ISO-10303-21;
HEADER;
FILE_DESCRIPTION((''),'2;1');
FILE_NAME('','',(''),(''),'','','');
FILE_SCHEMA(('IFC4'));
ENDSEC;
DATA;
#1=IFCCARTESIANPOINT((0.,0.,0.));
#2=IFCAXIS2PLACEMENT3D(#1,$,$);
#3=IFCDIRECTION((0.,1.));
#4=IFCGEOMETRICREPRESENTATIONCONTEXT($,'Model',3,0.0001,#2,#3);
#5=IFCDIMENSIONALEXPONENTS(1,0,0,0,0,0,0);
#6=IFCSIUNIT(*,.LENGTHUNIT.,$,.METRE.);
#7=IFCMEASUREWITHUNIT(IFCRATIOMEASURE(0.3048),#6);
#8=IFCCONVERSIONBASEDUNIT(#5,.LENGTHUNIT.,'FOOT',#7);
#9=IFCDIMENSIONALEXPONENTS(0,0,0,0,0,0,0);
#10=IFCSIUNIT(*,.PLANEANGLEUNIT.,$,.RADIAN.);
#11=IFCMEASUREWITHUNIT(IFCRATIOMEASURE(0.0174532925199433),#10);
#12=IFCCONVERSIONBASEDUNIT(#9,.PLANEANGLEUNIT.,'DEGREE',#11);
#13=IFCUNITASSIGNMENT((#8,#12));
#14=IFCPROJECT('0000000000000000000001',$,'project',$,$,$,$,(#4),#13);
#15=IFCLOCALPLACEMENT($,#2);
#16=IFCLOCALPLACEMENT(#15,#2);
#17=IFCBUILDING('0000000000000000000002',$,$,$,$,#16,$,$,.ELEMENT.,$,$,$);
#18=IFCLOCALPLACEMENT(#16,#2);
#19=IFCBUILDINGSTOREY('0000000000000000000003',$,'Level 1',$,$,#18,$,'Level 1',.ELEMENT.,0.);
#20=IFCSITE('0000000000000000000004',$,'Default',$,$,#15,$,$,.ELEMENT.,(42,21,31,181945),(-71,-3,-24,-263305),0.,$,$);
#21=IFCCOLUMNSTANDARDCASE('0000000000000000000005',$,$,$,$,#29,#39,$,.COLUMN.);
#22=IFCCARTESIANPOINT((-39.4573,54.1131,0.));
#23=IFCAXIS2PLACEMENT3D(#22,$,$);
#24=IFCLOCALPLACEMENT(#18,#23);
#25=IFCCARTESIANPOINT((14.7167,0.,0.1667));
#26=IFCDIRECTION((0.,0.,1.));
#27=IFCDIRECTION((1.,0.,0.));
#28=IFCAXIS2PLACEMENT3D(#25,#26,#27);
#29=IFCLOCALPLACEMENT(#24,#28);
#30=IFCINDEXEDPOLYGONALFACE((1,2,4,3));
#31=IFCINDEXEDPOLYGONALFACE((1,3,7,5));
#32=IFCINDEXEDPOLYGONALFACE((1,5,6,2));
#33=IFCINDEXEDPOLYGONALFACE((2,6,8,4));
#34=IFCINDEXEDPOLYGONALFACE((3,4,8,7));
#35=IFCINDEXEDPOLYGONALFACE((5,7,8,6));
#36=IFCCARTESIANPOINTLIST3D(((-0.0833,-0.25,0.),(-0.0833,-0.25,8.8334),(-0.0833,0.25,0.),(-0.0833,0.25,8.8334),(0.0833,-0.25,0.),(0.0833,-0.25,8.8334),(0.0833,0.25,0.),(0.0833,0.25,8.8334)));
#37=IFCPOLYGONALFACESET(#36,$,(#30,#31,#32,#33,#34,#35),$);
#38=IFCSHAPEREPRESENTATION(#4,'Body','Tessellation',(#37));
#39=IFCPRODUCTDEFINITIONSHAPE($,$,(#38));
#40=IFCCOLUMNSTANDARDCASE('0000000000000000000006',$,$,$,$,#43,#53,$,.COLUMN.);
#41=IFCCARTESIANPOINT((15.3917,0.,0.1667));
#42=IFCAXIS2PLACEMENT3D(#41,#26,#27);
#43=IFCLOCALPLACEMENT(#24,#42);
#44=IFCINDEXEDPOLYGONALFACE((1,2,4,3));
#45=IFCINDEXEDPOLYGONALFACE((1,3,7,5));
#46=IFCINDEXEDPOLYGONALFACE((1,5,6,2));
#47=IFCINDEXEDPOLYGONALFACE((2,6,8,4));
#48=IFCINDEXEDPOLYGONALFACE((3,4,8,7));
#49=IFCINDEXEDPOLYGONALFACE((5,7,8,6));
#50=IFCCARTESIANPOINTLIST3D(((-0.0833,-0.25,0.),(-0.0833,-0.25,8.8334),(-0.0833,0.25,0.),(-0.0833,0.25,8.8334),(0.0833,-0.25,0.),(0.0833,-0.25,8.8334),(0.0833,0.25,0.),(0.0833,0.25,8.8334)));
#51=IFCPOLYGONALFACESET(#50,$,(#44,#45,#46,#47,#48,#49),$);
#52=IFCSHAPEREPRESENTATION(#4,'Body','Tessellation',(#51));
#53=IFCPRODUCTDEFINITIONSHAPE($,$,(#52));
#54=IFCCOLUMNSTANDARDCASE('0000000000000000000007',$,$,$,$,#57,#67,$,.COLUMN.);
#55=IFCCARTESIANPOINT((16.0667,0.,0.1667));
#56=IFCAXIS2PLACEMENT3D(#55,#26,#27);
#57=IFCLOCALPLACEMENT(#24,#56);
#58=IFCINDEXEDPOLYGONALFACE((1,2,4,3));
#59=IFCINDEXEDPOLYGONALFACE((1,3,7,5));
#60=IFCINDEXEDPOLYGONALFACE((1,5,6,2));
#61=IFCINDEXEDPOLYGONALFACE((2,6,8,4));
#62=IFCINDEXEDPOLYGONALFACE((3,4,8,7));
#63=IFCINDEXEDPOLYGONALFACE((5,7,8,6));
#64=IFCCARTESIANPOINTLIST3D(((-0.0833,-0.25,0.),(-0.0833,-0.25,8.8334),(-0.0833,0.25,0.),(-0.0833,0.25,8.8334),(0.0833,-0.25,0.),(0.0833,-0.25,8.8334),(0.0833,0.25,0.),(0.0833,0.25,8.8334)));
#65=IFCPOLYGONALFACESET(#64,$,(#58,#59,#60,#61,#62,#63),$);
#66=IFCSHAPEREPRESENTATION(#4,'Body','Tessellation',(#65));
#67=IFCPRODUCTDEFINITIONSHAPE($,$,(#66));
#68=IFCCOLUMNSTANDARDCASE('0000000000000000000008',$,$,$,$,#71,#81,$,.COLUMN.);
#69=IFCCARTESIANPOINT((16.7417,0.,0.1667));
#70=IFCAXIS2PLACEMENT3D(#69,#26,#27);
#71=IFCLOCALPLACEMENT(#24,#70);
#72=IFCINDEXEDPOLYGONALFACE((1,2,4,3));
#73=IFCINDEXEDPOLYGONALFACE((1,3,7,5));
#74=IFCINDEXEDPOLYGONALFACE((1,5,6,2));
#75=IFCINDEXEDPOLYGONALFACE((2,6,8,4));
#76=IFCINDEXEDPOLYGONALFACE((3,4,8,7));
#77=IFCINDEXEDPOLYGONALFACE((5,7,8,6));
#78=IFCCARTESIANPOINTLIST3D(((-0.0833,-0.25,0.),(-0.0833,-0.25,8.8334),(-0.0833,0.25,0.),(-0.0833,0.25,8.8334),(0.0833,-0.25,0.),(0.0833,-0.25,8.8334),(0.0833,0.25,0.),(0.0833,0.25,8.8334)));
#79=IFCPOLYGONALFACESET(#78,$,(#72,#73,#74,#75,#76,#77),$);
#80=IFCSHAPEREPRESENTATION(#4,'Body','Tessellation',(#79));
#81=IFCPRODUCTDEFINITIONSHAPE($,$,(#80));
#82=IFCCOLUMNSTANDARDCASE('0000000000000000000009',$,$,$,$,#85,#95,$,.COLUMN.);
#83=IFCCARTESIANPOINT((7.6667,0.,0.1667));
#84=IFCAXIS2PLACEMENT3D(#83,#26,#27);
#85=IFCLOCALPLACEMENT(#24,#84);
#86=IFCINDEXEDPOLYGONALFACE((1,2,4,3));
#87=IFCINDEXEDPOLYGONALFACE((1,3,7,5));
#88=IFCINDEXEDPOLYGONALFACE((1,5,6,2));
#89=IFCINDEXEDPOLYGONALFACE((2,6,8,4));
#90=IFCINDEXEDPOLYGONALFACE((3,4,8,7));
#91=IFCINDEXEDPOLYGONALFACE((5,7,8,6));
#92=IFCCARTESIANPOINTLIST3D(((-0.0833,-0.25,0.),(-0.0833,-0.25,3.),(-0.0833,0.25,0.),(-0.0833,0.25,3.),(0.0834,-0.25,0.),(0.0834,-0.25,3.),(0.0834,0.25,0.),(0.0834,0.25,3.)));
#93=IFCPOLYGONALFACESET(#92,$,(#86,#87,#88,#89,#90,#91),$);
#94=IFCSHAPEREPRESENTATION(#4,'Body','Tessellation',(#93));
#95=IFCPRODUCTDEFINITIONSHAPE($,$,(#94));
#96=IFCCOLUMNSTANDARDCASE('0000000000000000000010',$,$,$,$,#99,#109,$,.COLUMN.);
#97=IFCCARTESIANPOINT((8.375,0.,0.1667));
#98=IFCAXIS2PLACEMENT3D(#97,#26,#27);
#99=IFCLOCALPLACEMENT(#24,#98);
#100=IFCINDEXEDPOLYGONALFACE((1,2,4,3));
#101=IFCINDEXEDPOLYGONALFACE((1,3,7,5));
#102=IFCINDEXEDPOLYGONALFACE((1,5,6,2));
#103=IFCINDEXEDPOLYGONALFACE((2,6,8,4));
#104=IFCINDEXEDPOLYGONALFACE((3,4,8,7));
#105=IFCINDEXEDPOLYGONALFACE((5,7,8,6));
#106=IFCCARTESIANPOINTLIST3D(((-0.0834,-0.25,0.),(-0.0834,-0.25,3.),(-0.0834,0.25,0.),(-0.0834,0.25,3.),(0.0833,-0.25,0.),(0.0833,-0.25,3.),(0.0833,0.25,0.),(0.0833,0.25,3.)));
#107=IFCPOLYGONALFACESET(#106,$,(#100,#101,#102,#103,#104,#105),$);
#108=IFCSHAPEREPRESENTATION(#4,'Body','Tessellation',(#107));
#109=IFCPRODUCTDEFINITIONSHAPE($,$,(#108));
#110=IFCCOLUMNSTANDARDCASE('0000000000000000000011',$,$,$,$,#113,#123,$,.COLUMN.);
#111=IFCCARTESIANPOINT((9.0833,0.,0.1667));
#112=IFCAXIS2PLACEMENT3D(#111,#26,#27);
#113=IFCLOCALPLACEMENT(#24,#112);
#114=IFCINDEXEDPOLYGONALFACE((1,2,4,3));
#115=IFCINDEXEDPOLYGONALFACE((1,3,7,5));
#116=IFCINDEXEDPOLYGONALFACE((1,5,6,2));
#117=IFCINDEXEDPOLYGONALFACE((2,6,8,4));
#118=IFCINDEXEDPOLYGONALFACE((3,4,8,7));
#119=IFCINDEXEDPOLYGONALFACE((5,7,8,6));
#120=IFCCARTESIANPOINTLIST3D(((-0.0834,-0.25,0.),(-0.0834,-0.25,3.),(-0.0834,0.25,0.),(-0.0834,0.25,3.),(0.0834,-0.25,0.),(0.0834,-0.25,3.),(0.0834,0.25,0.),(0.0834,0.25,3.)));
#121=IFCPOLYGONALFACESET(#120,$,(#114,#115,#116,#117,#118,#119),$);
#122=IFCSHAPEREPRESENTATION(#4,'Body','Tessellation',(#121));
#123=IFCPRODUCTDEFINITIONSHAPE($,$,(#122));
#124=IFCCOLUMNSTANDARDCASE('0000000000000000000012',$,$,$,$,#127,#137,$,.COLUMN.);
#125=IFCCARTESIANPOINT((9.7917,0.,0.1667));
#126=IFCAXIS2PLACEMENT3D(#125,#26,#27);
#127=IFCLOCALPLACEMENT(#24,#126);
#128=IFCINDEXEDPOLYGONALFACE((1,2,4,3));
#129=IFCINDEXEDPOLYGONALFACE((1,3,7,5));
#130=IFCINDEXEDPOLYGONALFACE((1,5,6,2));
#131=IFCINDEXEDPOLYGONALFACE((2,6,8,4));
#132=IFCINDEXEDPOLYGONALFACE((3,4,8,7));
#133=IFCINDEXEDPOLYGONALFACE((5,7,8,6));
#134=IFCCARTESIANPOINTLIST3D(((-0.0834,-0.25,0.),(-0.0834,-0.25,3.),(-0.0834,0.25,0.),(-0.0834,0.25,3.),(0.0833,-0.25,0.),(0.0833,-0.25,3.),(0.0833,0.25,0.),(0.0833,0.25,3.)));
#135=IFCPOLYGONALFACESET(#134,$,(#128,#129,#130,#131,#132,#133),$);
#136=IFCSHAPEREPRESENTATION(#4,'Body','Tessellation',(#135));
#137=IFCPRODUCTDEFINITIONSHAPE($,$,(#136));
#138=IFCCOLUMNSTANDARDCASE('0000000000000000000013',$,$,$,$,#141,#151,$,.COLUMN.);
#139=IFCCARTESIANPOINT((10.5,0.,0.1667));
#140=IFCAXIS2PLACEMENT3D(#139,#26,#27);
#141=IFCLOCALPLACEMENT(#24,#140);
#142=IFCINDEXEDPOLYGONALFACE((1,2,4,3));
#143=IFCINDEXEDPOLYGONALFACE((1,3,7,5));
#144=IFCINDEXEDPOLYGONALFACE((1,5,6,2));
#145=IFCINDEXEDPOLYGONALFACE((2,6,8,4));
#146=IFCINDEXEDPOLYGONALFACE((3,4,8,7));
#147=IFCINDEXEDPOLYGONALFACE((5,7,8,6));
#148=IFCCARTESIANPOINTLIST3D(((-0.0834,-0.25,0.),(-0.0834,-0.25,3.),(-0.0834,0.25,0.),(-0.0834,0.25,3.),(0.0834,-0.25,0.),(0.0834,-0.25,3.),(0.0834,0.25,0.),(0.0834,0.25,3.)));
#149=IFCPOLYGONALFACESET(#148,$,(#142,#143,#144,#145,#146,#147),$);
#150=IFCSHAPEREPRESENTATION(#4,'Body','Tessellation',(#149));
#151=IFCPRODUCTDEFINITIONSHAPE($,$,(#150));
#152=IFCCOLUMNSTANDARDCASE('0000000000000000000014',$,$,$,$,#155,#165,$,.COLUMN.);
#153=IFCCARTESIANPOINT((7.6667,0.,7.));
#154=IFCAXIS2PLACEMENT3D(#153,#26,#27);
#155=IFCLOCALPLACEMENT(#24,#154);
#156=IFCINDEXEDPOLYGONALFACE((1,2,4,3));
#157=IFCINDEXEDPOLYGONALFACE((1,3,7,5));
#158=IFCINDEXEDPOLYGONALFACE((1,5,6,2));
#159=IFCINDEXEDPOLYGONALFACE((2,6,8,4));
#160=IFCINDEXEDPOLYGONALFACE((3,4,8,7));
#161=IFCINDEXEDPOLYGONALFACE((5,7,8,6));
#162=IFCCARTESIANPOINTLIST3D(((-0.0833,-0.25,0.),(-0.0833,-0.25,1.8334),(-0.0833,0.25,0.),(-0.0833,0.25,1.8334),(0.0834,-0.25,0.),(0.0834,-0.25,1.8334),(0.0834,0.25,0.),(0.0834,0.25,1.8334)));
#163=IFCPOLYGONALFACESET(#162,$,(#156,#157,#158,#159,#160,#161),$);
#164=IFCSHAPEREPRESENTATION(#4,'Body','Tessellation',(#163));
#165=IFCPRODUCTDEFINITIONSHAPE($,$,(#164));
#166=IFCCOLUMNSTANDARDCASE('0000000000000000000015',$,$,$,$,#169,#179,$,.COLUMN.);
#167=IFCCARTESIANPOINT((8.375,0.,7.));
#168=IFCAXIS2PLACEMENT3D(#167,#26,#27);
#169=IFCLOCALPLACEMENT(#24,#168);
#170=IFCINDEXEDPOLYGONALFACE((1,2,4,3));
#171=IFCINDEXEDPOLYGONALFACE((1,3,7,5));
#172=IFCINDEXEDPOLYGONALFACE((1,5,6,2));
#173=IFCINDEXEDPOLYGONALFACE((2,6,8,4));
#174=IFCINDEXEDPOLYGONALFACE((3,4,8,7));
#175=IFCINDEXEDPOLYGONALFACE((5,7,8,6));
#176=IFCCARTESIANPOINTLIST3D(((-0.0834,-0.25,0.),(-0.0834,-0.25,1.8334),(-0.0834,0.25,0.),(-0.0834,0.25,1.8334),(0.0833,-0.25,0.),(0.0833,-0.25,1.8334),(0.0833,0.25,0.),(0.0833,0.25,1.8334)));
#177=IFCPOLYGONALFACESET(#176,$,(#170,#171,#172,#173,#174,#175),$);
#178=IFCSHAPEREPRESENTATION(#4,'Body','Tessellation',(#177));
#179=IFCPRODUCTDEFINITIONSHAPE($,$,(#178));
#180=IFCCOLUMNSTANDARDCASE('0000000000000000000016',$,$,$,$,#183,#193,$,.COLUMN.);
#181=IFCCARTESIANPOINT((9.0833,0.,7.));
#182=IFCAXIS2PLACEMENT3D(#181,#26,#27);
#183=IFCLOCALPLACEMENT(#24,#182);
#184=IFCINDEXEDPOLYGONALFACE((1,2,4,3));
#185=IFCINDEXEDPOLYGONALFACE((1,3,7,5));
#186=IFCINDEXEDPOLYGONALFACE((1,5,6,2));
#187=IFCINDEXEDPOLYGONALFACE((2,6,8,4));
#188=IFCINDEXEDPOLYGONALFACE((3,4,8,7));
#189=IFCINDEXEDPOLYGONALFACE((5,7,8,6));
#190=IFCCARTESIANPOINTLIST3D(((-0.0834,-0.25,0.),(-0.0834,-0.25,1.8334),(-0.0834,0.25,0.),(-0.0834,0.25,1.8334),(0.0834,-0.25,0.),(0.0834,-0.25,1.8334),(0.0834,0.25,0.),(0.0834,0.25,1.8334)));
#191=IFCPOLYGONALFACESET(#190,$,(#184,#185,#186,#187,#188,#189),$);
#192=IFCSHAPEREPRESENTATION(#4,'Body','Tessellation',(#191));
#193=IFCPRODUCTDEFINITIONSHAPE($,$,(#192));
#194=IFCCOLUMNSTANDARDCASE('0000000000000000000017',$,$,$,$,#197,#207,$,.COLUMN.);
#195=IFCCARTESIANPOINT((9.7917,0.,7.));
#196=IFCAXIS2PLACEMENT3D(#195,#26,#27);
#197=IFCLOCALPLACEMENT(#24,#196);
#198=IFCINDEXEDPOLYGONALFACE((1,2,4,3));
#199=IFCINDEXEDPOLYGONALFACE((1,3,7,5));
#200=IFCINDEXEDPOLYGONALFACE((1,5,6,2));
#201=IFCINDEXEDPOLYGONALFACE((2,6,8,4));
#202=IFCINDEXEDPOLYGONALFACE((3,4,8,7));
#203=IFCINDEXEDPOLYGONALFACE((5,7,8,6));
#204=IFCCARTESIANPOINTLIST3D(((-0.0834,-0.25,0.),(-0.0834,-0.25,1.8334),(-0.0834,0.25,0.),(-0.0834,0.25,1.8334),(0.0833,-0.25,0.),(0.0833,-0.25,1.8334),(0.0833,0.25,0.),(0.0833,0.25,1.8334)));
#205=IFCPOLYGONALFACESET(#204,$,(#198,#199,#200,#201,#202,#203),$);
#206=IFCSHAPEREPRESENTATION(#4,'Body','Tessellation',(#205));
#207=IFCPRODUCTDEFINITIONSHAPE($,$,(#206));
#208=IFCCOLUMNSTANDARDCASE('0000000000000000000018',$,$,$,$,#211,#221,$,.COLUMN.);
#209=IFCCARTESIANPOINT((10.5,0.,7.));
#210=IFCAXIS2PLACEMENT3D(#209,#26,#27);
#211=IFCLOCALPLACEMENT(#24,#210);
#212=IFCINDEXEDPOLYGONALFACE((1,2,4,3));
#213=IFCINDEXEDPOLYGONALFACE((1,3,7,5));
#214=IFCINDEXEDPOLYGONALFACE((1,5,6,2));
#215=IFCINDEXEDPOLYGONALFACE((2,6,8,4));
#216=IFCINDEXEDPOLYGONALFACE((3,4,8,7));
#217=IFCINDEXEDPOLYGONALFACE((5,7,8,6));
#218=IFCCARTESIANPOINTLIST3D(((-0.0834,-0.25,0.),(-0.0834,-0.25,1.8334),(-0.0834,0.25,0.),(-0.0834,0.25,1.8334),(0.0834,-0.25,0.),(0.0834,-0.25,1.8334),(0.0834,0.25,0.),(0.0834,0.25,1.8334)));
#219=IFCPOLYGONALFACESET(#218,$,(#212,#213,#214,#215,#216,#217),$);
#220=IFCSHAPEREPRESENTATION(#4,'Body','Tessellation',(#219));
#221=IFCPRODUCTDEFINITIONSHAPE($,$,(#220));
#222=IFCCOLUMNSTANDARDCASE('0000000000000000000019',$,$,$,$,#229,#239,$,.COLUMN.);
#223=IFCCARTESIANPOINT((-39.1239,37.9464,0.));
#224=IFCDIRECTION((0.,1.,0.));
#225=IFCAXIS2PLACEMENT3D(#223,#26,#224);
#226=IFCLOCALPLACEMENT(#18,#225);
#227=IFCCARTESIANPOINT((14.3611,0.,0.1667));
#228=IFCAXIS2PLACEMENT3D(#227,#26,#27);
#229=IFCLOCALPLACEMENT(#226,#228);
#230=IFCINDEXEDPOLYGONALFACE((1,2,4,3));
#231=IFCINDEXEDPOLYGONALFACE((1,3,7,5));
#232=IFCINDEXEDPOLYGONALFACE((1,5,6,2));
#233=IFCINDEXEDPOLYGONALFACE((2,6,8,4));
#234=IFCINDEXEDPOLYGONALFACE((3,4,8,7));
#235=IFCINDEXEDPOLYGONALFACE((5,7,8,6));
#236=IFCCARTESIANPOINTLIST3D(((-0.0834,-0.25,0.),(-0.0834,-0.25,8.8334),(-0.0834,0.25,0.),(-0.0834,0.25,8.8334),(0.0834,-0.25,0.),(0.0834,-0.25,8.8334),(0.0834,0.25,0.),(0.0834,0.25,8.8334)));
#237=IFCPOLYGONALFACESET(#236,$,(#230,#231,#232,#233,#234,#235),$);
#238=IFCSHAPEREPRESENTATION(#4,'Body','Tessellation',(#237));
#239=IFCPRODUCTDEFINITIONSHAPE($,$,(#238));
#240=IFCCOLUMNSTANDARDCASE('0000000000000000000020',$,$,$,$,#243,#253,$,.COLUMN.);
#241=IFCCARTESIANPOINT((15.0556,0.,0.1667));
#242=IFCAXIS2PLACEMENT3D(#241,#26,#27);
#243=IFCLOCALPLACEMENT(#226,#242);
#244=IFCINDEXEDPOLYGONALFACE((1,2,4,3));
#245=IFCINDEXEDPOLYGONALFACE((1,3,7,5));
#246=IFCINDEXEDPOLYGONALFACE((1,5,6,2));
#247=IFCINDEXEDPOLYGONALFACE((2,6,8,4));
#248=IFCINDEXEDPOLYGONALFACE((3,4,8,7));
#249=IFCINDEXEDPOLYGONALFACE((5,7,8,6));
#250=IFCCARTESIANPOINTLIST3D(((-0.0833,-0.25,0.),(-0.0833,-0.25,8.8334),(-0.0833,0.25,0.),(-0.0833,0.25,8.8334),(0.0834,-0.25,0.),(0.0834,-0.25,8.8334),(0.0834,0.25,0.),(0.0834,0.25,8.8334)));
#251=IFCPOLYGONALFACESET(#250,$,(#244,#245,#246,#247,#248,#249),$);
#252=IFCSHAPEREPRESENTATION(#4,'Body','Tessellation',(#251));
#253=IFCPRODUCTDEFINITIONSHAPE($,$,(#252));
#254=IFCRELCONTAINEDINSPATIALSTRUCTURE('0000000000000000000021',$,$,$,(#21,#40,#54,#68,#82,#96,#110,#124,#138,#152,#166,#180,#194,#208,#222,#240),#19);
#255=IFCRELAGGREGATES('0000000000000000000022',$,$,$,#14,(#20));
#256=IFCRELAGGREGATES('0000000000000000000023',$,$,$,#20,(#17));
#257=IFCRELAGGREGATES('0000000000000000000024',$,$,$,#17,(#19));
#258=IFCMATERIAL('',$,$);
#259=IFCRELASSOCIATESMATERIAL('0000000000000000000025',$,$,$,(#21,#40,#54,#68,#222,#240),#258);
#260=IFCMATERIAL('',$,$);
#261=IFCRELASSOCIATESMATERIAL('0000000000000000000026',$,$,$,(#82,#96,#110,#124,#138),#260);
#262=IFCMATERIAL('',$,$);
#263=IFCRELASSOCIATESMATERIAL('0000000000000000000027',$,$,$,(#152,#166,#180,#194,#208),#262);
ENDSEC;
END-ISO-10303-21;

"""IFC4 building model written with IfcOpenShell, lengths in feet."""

from ifc_helpers import new_model, entity, si_unit, converted_unit, direction, frame, origin, place, context, project, spatial, rectangle, extrude, material, element, save


model = new_model("IFC4")

# Units and contexts
model_context = context("Model", 3, precision=0.0001, world=origin(), true_north=direction((0.0, 1.0)))
ifc_project = project(units=[converted_unit("LENGTHUNIT", "FOOT", entity("IfcRatioMeasure", 0.3048), si_unit("LENGTHUNIT", "METRE"), dimensions=[1, 0, 0, 0, 0, 0, 0]), converted_unit("PLANEANGLEUNIT", "DEGREE", entity("IfcRatioMeasure", 0.0174532925199433), si_unit("PLANEANGLEUNIT", "RADIAN"), dimensions=[0, 0, 0, 0, 0, 0, 0])], contexts=[model_context])

# Site, building, storey
site_placement = place(None, origin())
site = spatial("IfcSite", under=ifc_project, at=site_placement, Name="Default", CompositionType="ELEMENT", RefLatitude=(42, 21, 31, 181945), RefLongitude=(-71, -3, -24, -263305), RefElevation=0.0)
building_placement = place(site_placement, origin())
building = spatial("IfcBuilding", under=site, at=building_placement, CompositionType="ELEMENT")
storey_placement = place(building_placement, origin())
storey = spatial("IfcBuildingStorey", under=building, at=storey_placement, Name="Level 1", LongName="Level 1", CompositionType="ELEMENT", Elevation=0.0)

# Columns
placement_1 = place(storey_placement, frame((-39.4573, 54.1131, 0.0)))
ifc_material_1 = material(Name="")
for number, where, z_axis, x_axis in (
    (1, (14.7167, 0.0, 0.1667), (0.0, 0.0, 1.0), (1.0, 0.0, 0.0)),
    (2, (15.3917, 0.0, 0.1667), (0.0, 0.0, 1.0), (1.0, 0.0, 0.0)),
    (3, (16.0667, 0.0, 0.1667), (0.0, 0.0, 1.0), (1.0, 0.0, 0.0)),
    (4, (16.7417, 0.0, 0.1667), (0.0, 0.0, 1.0), (1.0, 0.0, 0.0)),
):
    element("IfcColumnStandardCase", number, at=place(placement_1, frame(where, z_axis=z_axis, x_axis=x_axis)), inside=storey, material=ifc_material_1, PredefinedType="COLUMN", context=model_context, shape_type="SweptSolid", body=[
        extrude(rectangle(XDim=0.1667, YDim=0.5), origin(), (0.0, 0.0, 1.0), 8.8334),
    ])
ifc_material_2 = material(Name="")
for number, where, z_axis, x_axis in (
    (5, (7.6667, 0.0, 0.1667), (0.0, 0.0, 1.0), (1.0, 0.0, 0.0)),
    (6, (8.375, 0.0, 0.1667), (0.0, 0.0, 1.0), (1.0, 0.0, 0.0)),
    (7, (9.0833, 0.0, 0.1667), (0.0, 0.0, 1.0), (1.0, 0.0, 0.0)),
    (8, (9.7917, 0.0, 0.1667), (0.0, 0.0, 1.0), (1.0, 0.0, 0.0)),
    (9, (10.5, 0.0, 0.1667), (0.0, 0.0, 1.0), (1.0, 0.0, 0.0)),
):
    element("IfcColumnStandardCase", number, at=place(placement_1, frame(where, z_axis=z_axis, x_axis=x_axis)), inside=storey, material=ifc_material_2, PredefinedType="COLUMN", context=model_context, shape_type="SweptSolid", body=[
        extrude(rectangle(XDim=0.1667, YDim=0.5), origin(), (0.0, 0.0, 1.0), 3.0),
    ])
ifc_material_3 = material(Name="")
for number, where, z_axis, x_axis in (
    (10, (7.6667, 0.0, 7.0), (0.0, 0.0, 1.0), (1.0, 0.0, 0.0)),
    (11, (8.375, 0.0, 7.0), (0.0, 0.0, 1.0), (1.0, 0.0, 0.0)),
    (12, (9.0833, 0.0, 7.0), (0.0, 0.0, 1.0), (1.0, 0.0, 0.0)),
    (13, (9.7917, 0.0, 7.0), (0.0, 0.0, 1.0), (1.0, 0.0, 0.0)),
    (14, (10.5, 0.0, 7.0), (0.0, 0.0, 1.0), (1.0, 0.0, 0.0)),
):
    element("IfcColumnStandardCase", number, at=place(placement_1, frame(where, z_axis=z_axis, x_axis=x_axis)), inside=storey, material=ifc_material_3, PredefinedType="COLUMN", context=model_context, shape_type="SweptSolid", body=[
        extrude(rectangle(XDim=0.1667, YDim=0.5), origin(), (0.0, 0.0, 1.0), 1.8334),
    ])
placement_2 = place(storey_placement, frame((-39.1239, 37.9464, 0.0), z_axis=(0.0, 0.0, 1.0), x_axis=(0.0, 1.0, 0.0)))
for number, where, z_axis, x_axis in (
    (15, (14.3611, 0.0, 0.1667), (0.0, 0.0, 1.0), (1.0, 0.0, 0.0)),
    (16, (15.0556, 0.0, 0.1667), (0.0, 0.0, 1.0), (1.0, 0.0, 0.0)),
):
    element("IfcColumnStandardCase", number, at=place(placement_2, frame(where, z_axis=z_axis, x_axis=x_axis)), inside=storey, material=ifc_material_1, PredefinedType="COLUMN", context=model_context, shape_type="SweptSolid", body=[
        extrude(rectangle(XDim=0.1667, YDim=0.5), origin(), (0.0, 0.0, 1.0), 8.8334),
    ])

save(model, "model.ifc")
